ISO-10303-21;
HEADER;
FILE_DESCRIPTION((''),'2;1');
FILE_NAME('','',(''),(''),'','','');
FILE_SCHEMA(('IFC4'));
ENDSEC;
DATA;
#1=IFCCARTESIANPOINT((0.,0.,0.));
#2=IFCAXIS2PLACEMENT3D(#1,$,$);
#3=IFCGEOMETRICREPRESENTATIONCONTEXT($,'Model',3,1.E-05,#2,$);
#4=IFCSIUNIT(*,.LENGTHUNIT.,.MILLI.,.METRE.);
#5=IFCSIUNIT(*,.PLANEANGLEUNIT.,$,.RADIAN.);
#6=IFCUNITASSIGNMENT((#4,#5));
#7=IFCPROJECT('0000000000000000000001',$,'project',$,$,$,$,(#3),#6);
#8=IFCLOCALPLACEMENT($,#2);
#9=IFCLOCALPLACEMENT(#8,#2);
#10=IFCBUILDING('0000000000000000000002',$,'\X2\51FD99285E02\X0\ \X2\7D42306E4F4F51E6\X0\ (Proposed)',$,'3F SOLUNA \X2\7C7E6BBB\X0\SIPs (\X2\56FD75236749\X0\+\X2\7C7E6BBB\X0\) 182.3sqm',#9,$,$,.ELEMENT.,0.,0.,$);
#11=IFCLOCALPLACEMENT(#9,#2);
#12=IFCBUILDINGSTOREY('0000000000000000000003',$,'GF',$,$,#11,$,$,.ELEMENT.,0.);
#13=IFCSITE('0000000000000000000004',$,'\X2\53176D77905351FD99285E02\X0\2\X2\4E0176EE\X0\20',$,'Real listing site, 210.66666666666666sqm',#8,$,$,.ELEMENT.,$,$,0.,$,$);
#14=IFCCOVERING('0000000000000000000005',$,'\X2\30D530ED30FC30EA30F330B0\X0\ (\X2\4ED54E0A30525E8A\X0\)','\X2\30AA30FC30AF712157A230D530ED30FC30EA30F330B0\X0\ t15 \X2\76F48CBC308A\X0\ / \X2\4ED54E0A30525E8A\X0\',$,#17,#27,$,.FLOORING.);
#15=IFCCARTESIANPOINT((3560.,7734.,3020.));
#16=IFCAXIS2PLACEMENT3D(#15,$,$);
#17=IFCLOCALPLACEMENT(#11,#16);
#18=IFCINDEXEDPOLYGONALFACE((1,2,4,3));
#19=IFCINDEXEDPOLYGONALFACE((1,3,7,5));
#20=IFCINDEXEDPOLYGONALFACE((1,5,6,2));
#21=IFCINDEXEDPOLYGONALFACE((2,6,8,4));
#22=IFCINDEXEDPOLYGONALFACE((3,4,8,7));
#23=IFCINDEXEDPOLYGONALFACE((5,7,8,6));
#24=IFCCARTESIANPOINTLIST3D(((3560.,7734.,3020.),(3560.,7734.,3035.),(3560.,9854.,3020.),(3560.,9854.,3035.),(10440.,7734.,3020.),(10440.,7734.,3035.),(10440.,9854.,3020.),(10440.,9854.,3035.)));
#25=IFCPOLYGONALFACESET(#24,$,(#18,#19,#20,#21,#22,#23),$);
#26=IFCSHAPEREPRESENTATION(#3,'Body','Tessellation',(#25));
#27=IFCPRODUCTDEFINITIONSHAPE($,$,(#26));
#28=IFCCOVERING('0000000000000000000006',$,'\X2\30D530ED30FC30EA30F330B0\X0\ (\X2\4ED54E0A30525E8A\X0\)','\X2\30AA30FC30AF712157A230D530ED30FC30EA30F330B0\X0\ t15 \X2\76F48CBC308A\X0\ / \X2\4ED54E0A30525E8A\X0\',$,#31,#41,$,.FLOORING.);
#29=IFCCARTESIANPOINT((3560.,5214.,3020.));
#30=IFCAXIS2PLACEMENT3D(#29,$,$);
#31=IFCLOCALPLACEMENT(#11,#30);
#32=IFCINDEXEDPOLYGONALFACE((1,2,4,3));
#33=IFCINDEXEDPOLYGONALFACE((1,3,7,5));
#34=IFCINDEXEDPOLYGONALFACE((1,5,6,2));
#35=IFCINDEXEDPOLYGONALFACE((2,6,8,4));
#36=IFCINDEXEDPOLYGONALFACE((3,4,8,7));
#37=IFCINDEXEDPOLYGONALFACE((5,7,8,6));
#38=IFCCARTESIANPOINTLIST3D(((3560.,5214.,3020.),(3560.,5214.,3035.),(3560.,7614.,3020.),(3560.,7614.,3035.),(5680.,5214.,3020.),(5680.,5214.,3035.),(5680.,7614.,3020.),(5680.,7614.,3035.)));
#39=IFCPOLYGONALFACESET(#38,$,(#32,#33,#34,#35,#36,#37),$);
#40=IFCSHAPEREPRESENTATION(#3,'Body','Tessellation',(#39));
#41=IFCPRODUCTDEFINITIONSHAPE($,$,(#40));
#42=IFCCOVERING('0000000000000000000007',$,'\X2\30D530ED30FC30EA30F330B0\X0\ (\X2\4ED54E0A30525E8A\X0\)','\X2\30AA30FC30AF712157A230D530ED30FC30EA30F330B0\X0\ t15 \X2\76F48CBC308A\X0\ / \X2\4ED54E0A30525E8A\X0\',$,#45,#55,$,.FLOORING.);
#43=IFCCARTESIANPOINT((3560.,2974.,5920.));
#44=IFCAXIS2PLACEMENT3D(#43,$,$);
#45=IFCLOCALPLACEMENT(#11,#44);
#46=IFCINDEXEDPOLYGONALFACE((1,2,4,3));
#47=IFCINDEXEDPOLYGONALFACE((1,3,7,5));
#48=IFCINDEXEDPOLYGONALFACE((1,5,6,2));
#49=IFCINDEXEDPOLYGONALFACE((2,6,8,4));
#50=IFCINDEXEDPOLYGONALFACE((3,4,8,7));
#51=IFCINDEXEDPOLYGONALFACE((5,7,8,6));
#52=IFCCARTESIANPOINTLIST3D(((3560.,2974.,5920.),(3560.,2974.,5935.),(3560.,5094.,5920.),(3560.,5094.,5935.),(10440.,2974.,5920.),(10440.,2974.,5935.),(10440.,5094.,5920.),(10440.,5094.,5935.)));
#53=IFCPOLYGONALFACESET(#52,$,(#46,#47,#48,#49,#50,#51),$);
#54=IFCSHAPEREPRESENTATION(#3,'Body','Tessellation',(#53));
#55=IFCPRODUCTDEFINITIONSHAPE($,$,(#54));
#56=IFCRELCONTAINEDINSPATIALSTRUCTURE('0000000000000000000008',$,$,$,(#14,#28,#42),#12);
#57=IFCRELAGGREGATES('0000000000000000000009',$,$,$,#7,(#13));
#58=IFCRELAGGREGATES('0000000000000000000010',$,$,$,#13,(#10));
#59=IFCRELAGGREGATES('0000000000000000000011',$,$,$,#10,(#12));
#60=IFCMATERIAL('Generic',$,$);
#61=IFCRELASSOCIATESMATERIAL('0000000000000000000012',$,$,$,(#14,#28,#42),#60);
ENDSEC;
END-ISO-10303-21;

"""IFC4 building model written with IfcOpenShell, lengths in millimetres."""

from ifc_helpers import new_model, si_unit, frame, frame_2d, origin, place, context, project, spatial, rectangle, extrude, material, element, save


model = new_model("IFC4")

# Units and contexts
model_context = context("Model", 3, precision=1e-05, world=origin())
ifc_project = project(units=[si_unit("LENGTHUNIT", "METRE", prefix="MILLI"), si_unit("PLANEANGLEUNIT", "RADIAN")], contexts=[model_context])

# Site, building, storey
site_placement = place(None, origin())
site = spatial("IfcSite", under=ifc_project, at=site_placement, Name="北海道函館市2丁目20", ObjectType="Real listing site, 210.66666666666666sqm", CompositionType="ELEMENT", RefElevation=0.0)
building_placement = place(site_placement, origin())
building = spatial("IfcBuilding", under=site, at=building_placement, Name="函館市 終の住処 (Proposed)", ObjectType="3F SOLUNA 籾殻SIPs (国産杉+籾殻) 182.3sqm", CompositionType="ELEMENT", ElevationOfRefHeight=0.0, ElevationOfTerrain=0.0)
storey_placement = place(building_placement, origin())
storey = spatial("IfcBuildingStorey", under=building, at=storey_placement, Name="GF", CompositionType="ELEMENT", Elevation=0.0)

# Shared definitions
ifc_material_1 = material(Name="Generic")

# Coverings
covering_1_placement = place(storey_placement, frame((3560.0, 7734.0, 3020.0)))
element("IfcCovering", 1, at=covering_1_placement, inside=storey, material=ifc_material_1, Name="フローリング (仕上げ床)", Description="オーク無垢フローリング t15 直貼り / 仕上げ床", PredefinedType="FLOORING", context=model_context, shape_type="SweptSolid", body=[
    extrude(rectangle(XDim=6880.0, YDim=2120.0, at=frame_2d((3440.0, 1060.0))), frame((3560.0, 7734.0, 3020.0)), (0.0, 0.0, 1.0), 15.0),
])
covering_2_placement = place(storey_placement, frame((3560.0, 5214.0, 3020.0)))
element("IfcCovering", 2, at=covering_2_placement, inside=storey, material=ifc_material_1, Name="フローリング (仕上げ床)", Description="オーク無垢フローリング t15 直貼り / 仕上げ床", PredefinedType="FLOORING", context=model_context, shape_type="SweptSolid", body=[
    extrude(rectangle(XDim=2120.0, YDim=2400.0, at=frame_2d((1060.0, 1200.0))), frame((3560.0, 5214.0, 3020.0)), (0.0, 0.0, 1.0), 15.0),
])
covering_3_placement = place(storey_placement, frame((3560.0, 2974.0, 5920.0)))
element("IfcCovering", 3, at=covering_3_placement, inside=storey, material=ifc_material_1, Name="フローリング (仕上げ床)", Description="オーク無垢フローリング t15 直貼り / 仕上げ床", PredefinedType="FLOORING", context=model_context, shape_type="SweptSolid", body=[
    extrude(rectangle(XDim=6880.0, YDim=2120.0, at=frame_2d((3440.0, 1060.0))), frame((3560.0, 2974.0, 5920.0)), (0.0, 0.0, 1.0), 15.0),
])

save(model, "model.ifc")
